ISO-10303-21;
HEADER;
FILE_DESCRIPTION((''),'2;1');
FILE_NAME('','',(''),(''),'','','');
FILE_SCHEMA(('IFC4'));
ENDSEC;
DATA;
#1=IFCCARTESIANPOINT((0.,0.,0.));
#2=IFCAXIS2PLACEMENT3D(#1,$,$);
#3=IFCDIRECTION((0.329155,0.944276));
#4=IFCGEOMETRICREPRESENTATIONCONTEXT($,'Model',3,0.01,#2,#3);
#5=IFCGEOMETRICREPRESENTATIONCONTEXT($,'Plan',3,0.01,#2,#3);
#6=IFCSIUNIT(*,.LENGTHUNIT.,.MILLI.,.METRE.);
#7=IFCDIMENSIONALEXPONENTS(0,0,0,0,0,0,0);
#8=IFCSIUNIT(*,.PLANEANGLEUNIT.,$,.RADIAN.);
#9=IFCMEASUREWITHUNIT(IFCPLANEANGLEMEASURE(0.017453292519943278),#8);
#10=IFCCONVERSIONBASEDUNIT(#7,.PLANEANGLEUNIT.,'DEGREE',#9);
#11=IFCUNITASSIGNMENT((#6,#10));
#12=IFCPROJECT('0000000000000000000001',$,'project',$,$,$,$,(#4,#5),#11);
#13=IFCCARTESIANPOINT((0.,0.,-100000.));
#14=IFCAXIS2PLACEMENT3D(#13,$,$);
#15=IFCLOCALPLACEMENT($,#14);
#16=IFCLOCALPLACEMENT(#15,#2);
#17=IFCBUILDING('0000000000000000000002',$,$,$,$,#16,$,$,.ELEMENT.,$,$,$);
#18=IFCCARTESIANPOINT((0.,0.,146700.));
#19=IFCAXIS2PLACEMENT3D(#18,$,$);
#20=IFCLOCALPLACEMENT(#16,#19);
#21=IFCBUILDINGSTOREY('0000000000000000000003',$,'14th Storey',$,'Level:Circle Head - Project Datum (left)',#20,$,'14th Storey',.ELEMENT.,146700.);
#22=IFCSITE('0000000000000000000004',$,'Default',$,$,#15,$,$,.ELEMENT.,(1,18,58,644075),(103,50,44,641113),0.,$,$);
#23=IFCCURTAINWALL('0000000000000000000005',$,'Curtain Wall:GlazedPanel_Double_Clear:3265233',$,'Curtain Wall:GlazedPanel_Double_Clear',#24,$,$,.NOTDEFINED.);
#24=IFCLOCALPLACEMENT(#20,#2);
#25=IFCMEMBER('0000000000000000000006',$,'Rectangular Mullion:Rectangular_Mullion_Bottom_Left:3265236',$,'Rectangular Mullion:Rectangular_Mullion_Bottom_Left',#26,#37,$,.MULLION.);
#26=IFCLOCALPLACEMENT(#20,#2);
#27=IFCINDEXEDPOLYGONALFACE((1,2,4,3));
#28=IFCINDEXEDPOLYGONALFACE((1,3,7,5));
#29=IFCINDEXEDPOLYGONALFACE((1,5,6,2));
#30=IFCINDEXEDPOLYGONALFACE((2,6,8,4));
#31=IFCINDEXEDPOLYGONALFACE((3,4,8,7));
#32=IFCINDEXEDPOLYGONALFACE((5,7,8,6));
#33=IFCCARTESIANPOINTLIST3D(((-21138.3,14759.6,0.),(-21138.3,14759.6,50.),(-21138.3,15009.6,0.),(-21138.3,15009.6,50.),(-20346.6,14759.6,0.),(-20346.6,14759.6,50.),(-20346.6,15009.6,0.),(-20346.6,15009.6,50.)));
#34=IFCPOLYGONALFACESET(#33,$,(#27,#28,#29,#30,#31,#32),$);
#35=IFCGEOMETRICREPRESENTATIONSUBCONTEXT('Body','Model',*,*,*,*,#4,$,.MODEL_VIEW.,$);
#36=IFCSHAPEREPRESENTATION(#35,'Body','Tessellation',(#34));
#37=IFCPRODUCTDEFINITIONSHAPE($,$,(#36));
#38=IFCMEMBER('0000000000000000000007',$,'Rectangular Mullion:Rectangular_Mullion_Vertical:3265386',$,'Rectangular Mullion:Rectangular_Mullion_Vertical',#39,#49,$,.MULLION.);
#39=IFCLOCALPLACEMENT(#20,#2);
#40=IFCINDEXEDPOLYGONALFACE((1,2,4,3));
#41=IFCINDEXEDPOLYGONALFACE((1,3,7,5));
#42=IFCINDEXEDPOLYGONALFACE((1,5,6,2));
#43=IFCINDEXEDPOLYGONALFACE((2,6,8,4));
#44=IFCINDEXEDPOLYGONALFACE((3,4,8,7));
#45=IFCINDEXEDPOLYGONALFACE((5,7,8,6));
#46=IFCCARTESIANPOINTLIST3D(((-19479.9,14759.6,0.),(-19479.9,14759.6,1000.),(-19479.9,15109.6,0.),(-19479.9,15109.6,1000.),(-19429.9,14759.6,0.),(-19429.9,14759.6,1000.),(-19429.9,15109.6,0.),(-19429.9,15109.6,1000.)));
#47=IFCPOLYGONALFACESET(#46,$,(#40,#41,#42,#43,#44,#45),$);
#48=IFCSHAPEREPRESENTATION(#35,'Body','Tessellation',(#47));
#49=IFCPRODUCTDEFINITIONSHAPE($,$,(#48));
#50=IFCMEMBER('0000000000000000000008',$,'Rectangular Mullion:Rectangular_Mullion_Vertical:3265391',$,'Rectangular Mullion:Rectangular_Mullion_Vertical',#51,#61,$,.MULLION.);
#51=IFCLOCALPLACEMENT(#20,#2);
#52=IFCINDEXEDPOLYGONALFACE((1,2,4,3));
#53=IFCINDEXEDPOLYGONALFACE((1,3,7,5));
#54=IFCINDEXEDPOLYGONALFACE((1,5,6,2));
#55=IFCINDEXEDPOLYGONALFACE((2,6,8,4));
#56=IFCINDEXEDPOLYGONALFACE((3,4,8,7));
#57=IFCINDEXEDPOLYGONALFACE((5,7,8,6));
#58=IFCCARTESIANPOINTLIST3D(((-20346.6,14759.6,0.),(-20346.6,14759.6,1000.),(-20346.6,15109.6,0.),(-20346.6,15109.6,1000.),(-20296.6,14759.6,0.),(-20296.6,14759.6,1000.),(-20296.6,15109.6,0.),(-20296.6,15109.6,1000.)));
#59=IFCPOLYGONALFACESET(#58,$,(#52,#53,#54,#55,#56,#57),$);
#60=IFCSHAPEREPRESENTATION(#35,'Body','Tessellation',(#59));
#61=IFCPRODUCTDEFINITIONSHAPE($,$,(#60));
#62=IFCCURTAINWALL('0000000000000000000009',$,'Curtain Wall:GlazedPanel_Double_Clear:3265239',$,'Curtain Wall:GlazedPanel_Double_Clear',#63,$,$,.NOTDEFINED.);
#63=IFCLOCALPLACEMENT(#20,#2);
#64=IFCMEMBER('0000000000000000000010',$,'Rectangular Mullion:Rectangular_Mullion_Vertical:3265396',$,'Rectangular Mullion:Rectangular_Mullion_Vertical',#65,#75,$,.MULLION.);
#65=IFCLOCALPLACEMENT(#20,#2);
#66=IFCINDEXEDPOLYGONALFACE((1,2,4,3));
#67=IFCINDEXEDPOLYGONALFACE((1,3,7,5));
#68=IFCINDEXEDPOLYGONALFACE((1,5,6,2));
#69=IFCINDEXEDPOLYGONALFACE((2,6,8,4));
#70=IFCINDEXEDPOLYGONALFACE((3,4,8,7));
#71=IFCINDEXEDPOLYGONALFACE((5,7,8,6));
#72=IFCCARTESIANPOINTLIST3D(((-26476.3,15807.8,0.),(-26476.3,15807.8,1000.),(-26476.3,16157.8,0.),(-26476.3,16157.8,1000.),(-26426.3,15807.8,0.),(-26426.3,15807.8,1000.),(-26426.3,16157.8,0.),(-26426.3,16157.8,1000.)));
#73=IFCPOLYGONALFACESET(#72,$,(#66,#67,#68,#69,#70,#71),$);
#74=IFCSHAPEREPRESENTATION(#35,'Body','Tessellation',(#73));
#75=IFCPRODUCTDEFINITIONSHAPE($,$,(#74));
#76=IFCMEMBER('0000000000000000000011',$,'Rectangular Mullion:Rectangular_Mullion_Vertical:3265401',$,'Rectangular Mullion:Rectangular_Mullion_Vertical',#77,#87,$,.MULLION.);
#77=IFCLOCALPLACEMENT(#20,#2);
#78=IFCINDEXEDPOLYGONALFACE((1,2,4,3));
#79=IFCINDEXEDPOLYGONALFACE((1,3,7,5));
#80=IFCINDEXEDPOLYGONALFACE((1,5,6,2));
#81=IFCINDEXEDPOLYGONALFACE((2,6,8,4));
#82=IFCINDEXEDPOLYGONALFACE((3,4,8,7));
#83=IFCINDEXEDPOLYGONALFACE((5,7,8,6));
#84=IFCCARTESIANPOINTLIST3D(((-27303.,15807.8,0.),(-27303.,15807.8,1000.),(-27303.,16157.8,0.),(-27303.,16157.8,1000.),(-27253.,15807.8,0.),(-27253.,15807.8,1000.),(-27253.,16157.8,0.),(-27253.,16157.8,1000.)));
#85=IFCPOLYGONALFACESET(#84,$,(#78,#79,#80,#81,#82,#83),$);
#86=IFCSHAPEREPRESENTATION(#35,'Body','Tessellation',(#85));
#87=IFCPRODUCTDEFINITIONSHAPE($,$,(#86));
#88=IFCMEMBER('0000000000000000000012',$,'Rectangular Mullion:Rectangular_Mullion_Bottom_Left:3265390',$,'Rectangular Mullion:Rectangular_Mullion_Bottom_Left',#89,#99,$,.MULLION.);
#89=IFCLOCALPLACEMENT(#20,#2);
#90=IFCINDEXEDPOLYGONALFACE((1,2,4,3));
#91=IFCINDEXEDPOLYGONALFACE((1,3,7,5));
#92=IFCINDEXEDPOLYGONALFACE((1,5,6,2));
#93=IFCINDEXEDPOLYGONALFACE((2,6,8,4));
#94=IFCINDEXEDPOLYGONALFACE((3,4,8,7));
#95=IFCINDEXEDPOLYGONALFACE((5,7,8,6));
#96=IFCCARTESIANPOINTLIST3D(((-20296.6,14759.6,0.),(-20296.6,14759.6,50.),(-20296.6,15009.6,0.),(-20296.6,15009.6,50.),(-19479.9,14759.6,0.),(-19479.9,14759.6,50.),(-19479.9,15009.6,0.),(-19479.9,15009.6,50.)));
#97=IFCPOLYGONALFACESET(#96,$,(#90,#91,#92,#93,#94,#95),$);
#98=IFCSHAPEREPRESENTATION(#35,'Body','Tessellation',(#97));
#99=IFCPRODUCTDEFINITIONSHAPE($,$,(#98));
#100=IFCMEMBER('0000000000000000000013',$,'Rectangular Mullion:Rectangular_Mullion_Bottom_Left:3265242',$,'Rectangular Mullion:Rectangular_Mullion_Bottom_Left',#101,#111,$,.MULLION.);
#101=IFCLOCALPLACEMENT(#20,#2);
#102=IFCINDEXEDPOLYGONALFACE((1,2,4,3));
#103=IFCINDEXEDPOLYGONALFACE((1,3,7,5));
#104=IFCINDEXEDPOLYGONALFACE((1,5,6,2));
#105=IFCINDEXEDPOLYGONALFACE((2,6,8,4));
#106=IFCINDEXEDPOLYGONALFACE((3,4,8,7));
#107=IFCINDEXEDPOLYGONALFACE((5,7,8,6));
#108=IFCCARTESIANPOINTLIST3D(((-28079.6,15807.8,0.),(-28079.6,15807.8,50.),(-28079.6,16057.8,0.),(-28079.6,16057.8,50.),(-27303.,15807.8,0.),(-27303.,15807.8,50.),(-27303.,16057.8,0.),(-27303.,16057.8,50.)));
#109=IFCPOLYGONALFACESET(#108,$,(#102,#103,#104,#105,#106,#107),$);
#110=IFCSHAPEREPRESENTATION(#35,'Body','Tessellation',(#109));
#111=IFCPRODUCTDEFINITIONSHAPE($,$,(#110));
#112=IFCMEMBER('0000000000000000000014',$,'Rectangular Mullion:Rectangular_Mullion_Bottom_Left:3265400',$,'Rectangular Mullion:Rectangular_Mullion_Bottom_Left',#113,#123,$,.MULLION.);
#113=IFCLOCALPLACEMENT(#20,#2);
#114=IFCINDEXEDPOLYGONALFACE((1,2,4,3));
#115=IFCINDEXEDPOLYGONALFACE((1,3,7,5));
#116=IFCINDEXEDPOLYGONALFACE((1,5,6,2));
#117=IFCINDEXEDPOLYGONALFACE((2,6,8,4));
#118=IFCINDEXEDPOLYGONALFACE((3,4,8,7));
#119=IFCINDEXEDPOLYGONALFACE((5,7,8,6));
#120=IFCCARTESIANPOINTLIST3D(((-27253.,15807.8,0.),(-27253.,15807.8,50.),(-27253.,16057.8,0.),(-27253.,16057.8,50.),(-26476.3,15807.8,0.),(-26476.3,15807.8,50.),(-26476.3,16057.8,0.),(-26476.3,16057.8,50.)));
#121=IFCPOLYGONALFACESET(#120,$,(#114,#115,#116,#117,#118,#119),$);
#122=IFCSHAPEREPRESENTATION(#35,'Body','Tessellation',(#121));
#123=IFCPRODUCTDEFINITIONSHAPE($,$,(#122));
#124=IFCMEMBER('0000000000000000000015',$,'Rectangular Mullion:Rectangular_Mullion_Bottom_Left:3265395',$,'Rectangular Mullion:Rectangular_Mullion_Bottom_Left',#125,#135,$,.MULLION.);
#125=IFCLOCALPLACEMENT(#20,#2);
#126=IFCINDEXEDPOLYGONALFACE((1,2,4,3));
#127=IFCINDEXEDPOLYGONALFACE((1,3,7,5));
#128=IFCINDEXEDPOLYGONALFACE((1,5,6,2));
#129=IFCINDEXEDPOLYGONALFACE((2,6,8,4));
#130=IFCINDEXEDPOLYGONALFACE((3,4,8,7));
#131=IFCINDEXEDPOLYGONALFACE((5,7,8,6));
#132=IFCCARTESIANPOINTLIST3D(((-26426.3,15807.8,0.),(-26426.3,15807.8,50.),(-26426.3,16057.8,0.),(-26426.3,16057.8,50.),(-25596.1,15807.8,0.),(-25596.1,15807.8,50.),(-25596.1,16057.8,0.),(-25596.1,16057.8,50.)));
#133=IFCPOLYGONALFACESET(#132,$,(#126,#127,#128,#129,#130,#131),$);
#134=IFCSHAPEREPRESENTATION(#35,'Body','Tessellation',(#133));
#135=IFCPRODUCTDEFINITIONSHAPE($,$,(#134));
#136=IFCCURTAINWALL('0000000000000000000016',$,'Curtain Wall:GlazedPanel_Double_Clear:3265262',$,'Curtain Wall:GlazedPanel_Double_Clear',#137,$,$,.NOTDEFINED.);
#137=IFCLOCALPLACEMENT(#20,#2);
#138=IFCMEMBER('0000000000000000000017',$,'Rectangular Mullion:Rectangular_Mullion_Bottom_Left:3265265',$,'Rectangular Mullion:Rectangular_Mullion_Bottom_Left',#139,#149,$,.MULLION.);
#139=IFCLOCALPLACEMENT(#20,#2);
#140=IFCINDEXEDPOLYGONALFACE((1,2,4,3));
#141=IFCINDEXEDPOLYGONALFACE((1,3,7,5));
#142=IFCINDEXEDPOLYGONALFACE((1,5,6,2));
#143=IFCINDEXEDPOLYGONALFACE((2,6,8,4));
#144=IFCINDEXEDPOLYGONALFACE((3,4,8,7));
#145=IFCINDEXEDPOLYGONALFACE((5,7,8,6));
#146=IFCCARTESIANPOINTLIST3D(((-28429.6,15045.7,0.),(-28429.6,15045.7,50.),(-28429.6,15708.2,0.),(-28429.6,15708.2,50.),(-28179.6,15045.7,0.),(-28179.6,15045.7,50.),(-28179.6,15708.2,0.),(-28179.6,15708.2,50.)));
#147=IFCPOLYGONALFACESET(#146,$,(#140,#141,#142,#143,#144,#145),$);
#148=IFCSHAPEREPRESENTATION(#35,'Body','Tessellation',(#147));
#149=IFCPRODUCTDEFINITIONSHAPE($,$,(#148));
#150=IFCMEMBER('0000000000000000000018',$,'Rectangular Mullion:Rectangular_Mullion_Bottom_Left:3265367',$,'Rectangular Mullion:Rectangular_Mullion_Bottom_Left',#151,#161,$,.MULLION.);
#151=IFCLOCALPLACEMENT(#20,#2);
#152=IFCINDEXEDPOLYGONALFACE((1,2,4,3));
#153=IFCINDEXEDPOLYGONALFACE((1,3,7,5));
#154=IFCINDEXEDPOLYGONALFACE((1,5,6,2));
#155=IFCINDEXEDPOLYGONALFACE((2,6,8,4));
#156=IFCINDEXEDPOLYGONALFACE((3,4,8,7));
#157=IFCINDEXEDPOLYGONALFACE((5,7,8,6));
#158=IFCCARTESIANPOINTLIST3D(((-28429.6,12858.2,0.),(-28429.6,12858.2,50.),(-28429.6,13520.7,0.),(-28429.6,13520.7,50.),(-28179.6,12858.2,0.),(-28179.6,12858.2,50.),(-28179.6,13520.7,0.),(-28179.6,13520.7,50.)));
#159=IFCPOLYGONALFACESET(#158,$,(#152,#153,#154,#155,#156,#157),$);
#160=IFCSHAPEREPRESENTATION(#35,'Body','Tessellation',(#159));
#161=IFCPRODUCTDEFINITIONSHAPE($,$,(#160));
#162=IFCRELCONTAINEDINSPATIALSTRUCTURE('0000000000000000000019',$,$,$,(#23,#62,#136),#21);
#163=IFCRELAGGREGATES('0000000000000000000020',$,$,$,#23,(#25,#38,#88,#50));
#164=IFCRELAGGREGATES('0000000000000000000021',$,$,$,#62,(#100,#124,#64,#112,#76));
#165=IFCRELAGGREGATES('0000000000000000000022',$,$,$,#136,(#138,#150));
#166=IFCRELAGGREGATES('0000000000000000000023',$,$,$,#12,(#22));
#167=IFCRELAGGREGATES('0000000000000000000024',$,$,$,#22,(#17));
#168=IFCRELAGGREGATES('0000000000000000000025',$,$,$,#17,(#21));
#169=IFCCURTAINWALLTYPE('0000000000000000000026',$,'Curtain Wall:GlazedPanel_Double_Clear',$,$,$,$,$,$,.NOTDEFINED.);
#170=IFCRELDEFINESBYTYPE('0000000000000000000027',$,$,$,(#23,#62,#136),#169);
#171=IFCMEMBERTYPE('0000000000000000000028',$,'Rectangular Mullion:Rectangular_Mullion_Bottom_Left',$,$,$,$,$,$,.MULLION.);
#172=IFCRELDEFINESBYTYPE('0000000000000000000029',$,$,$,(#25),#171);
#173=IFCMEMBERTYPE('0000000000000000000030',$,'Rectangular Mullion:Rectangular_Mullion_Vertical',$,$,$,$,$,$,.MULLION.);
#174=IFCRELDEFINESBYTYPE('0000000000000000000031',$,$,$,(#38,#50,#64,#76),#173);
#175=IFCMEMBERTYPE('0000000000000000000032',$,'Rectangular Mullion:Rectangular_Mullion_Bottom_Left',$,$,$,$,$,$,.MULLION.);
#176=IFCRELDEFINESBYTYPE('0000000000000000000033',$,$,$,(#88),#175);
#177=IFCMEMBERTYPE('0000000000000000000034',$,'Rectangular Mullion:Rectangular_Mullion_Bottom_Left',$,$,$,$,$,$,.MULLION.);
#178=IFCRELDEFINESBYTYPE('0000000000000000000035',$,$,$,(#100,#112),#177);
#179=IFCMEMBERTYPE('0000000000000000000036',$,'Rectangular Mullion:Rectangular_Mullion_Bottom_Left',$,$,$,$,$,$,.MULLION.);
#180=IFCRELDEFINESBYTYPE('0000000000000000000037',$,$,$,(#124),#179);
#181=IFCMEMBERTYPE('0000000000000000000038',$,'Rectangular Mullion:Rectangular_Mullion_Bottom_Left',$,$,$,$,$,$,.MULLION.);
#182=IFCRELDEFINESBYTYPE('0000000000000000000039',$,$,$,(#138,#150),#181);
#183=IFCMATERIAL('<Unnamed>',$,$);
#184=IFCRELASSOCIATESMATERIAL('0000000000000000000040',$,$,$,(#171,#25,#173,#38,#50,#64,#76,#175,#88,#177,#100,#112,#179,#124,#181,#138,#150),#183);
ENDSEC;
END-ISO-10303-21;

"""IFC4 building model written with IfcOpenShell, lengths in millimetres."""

from ifc_helpers import new_model, entity, si_unit, converted_unit, direction, frame, origin, place, context, subcontext, project, spatial, indexed_curve, outline, extrude, source, transform, mapped, material, type_object, type_shapes, element, aggregate, save


model = new_model("IFC4")

# Units and contexts
model_context = context("Model", 3, precision=0.01, world=origin(), true_north=direction((0.329155, 0.944276)))
plan_context = context("Plan", 3, precision=0.01, world=origin(), true_north=direction((0.329155, 0.944276)))
body_context = subcontext(model_context, "Body", "Model", "MODEL_VIEW")
ifc_project = project(units=[si_unit("LENGTHUNIT", "METRE", prefix="MILLI"), converted_unit("PLANEANGLEUNIT", "DEGREE", entity("IfcPlaneAngleMeasure", 0.017453292519943278), si_unit("PLANEANGLEUNIT", "RADIAN"), dimensions=[0, 0, 0, 0, 0, 0, 0])], contexts=[model_context, plan_context])

# Site, building, storey
site_placement = place(None, frame((0.0, 0.0, -100000.0)))
site = spatial("IfcSite", under=ifc_project, at=site_placement, Name="Default", CompositionType="ELEMENT", RefLatitude=(1, 18, 58, 644075), RefLongitude=(103, 50, 44, 641113), RefElevation=0.0)
building_placement = place(site_placement, origin())
building = spatial("IfcBuilding", under=site, at=building_placement, CompositionType="ELEMENT")
storey_placement = place(building_placement, frame((0.0, 0.0, 146700.0)))
storey = spatial("IfcBuildingStorey", under=building, at=storey_placement, Name="14th Storey", ObjectType="Level:Circle Head - Project Datum (left)", LongName="14th Storey", CompositionType="ELEMENT", Elevation=146700.0)

# Curtain walls, members
curtain_wall_type = type_object("IfcCurtainWallType", Name="Curtain Wall:GlazedPanel_Double_Clear", PredefinedType="NOTDEFINED")
curtain_wall_1_placement = place(storey_placement, frame((0.0, 0.0, -146700.0)))
curtain_wall_1 = element("IfcCurtainWall", 1, at=curtain_wall_1_placement, inside=storey, type_object=curtain_wall_type, Name="Curtain Wall:GlazedPanel_Double_Clear:3265233", ObjectType="Curtain Wall:GlazedPanel_Double_Clear", PredefinedType="NOTDEFINED")
ifc_material_1 = material(Name="<Unnamed>")
member_type_1 = type_object("IfcMemberType", Name="Rectangular Mullion:Rectangular_Mullion_Bottom_Left", PredefinedType="MULLION", material=ifc_material_1)
shared_shape_1 = source(origin(), body_context, "Body", "SweptSolid", [
    extrude(outline(indexed_curve([(-25.0, -125.0), (25.0, -125.0), (25.0, 125.0), (-25.0, 125.0), (-25.0, -125.0)], self_intersect=False)), frame((-25.0, 0.0, -791.7), z_axis=(0.0, 0.0, 1.0), x_axis=(-1.0, 0.0, 0.0)), (0.0, 0.0, 1.0), 791.7),
])
type_shapes(member_type_1, [shared_shape_1])
member_1_placement = place(curtain_wall_1_placement, frame((-21138.3, 14884.6, 146700.0), z_axis=(-1.0, 0.0, 0.0), x_axis=(0.0, 0.0, -1.0)))
member_1 = element("IfcMember", 2, at=member_1_placement, type_object=member_type_1, material=ifc_material_1, Name="Rectangular Mullion:Rectangular_Mullion_Bottom_Left:3265236", ObjectType="Rectangular Mullion:Rectangular_Mullion_Bottom_Left", PredefinedType="MULLION", context=body_context, shape_type="MappedRepresentation", body=[
    mapped(shared_shape_1, transform((0.0, 0.0, 0.0), scale=1.0)),
])
member_type_2 = type_object("IfcMemberType", Name="Rectangular Mullion:Rectangular_Mullion_Vertical", PredefinedType="MULLION", material=ifc_material_1)
shared_shape_2 = source(origin(), body_context, "Body", "SweptSolid", [
    extrude(outline(indexed_curve([(-25.0, -175.0), (25.0, -175.0), (25.0, 175.0), (-25.0, 175.0), (-25.0, -175.0)], self_intersect=False)), frame((0.0, -50.0, -1000.0), z_axis=(0.0, 0.0, 1.0), x_axis=(-1.0, 0.0, 0.0)), (0.0, 0.0, 1.0), 1000.0),
])
type_shapes(member_type_2, [shared_shape_2])
member_2_placement = place(curtain_wall_1_placement, frame((-19454.9, 14884.6, 146700.0), z_axis=(0.0, 0.0, -1.0), x_axis=(1.0, 0.0, 0.0)))
member_2 = element("IfcMember", 3, at=member_2_placement, type_object=member_type_2, material=ifc_material_1, Name="Rectangular Mullion:Rectangular_Mullion_Vertical:3265386", ObjectType="Rectangular Mullion:Rectangular_Mullion_Vertical", PredefinedType="MULLION", context=body_context, shape_type="MappedRepresentation", body=[
    mapped(shared_shape_2, transform((0.0, 0.0, 0.0), scale=1.0)),
])
member_3_placement = place(curtain_wall_1_placement, frame((-20321.6, 14884.6, 146700.0), z_axis=(0.0, 0.0, -1.0), x_axis=(1.0, 0.0, 0.0)))
member_3 = element("IfcMember", 4, at=member_3_placement, type_object=member_type_2, material=ifc_material_1, Name="Rectangular Mullion:Rectangular_Mullion_Vertical:3265391", ObjectType="Rectangular Mullion:Rectangular_Mullion_Vertical", PredefinedType="MULLION", context=body_context, shape_type="MappedRepresentation", body=[
    mapped(shared_shape_2, transform((0.0, 0.0, 0.0), scale=1.0)),
])
curtain_wall_2_placement = place(storey_placement, frame((0.0, 0.0, -146700.0)))
curtain_wall_2 = element("IfcCurtainWall", 5, at=curtain_wall_2_placement, inside=storey, type_object=curtain_wall_type, Name="Curtain Wall:GlazedPanel_Double_Clear:3265239", ObjectType="Curtain Wall:GlazedPanel_Double_Clear", PredefinedType="NOTDEFINED")
member_4_placement = place(curtain_wall_2_placement, frame((-26451.3, 15932.8, 146700.0), z_axis=(0.0, 0.0, -1.0), x_axis=(1.0, 0.0, 0.0)))
member_4 = element("IfcMember", 6, at=member_4_placement, type_object=member_type_2, material=ifc_material_1, Name="Rectangular Mullion:Rectangular_Mullion_Vertical:3265396", ObjectType="Rectangular Mullion:Rectangular_Mullion_Vertical", PredefinedType="MULLION", context=body_context, shape_type="MappedRepresentation", body=[
    mapped(shared_shape_2, transform((0.0, 0.0, 0.0), scale=1.0)),
])
member_5_placement = place(curtain_wall_2_placement, frame((-27278.0, 15932.8, 146700.0), z_axis=(0.0, 0.0, -1.0), x_axis=(1.0, 0.0, 0.0)))
member_5 = element("IfcMember", 7, at=member_5_placement, type_object=member_type_2, material=ifc_material_1, Name="Rectangular Mullion:Rectangular_Mullion_Vertical:3265401", ObjectType="Rectangular Mullion:Rectangular_Mullion_Vertical", PredefinedType="MULLION", context=body_context, shape_type="MappedRepresentation", body=[
    mapped(shared_shape_2, transform((0.0, 0.0, 0.0), scale=1.0)),
])

# Members
member_type_3 = type_object("IfcMemberType", Name="Rectangular Mullion:Rectangular_Mullion_Bottom_Left", PredefinedType="MULLION", material=ifc_material_1)
shared_shape_3 = source(origin(), body_context, "Body", "SweptSolid", [
    extrude(outline(indexed_curve([(-25.0, -125.0), (25.0, -125.0), (25.0, 125.0), (-25.0, 125.0), (-25.0, -125.0)], self_intersect=False)), frame((-25.0, 0.0, -816.7), z_axis=(0.0, 0.0, 1.0), x_axis=(-1.0, 0.0, 0.0)), (0.0, 0.0, 1.0), 816.7),
])
type_shapes(member_type_3, [shared_shape_3])
member_6_placement = place(curtain_wall_1_placement, frame((-20296.6, 14884.6, 146700.0), z_axis=(-1.0, 0.0, 0.0), x_axis=(0.0, 0.0, -1.0)))
member_6 = element("IfcMember", 8, at=member_6_placement, type_object=member_type_3, material=ifc_material_1, Name="Rectangular Mullion:Rectangular_Mullion_Bottom_Left:3265390", ObjectType="Rectangular Mullion:Rectangular_Mullion_Bottom_Left", PredefinedType="MULLION", context=body_context, shape_type="MappedRepresentation", body=[
    mapped(shared_shape_3, transform((0.0, 0.0, 0.0), scale=1.0)),
])
aggregate(curtain_wall_1, [member_1, member_2, member_6, member_3])
member_type_4 = type_object("IfcMemberType", Name="Rectangular Mullion:Rectangular_Mullion_Bottom_Left", PredefinedType="MULLION", material=ifc_material_1)
shared_shape_4 = source(origin(), body_context, "Body", "SweptSolid", [
    extrude(outline(indexed_curve([(-25.0, -125.0), (25.0, -125.0), (25.0, 125.0), (-25.0, 125.0), (-25.0, -125.0)], self_intersect=False)), frame((-25.0, 0.0, -776.7), z_axis=(0.0, 0.0, 1.0), x_axis=(-1.0, 0.0, 0.0)), (0.0, 0.0, 1.0), 776.7),
])
type_shapes(member_type_4, [shared_shape_4])
member_7_placement = place(curtain_wall_2_placement, frame((-28079.6, 15932.8, 146700.0), z_axis=(-1.0, 0.0, 0.0), x_axis=(0.0, 0.0, -1.0)))
member_7 = element("IfcMember", 9, at=member_7_placement, type_object=member_type_4, material=ifc_material_1, Name="Rectangular Mullion:Rectangular_Mullion_Bottom_Left:3265242", ObjectType="Rectangular Mullion:Rectangular_Mullion_Bottom_Left", PredefinedType="MULLION", context=body_context, shape_type="MappedRepresentation", body=[
    mapped(shared_shape_4, transform((0.0, 0.0, 0.0), scale=1.0)),
])
member_8_placement = place(curtain_wall_2_placement, frame((-27253.0, 15932.8, 146700.0), z_axis=(-1.0, 0.0, 0.0), x_axis=(0.0, 0.0, -1.0)))
member_8 = element("IfcMember", 10, at=member_8_placement, type_object=member_type_4, material=ifc_material_1, Name="Rectangular Mullion:Rectangular_Mullion_Bottom_Left:3265400", ObjectType="Rectangular Mullion:Rectangular_Mullion_Bottom_Left", PredefinedType="MULLION", context=body_context, shape_type="MappedRepresentation", body=[
    mapped(shared_shape_4, transform((0.0, 0.0, 0.0), scale=1.0)),
])
member_type_5 = type_object("IfcMemberType", Name="Rectangular Mullion:Rectangular_Mullion_Bottom_Left", PredefinedType="MULLION", material=ifc_material_1)
shared_shape_5 = source(origin(), body_context, "Body", "SweptSolid", [
    extrude(outline(indexed_curve([(-25.0, -125.0), (25.0, -125.0), (25.0, 125.0), (-25.0, 125.0), (-25.0, -125.0)], self_intersect=False)), frame((-25.0, 0.0, -830.2), z_axis=(0.0, 0.0, 1.0), x_axis=(-1.0, 0.0, 0.0)), (0.0, 0.0, 1.0), 830.2),
])
type_shapes(member_type_5, [shared_shape_5])
member_9_placement = place(curtain_wall_2_placement, frame((-26426.3, 15932.8, 146700.0), z_axis=(-1.0, 0.0, 0.0), x_axis=(0.0, 0.0, -1.0)))
member_9 = element("IfcMember", 11, at=member_9_placement, type_object=member_type_5, material=ifc_material_1, Name="Rectangular Mullion:Rectangular_Mullion_Bottom_Left:3265395", ObjectType="Rectangular Mullion:Rectangular_Mullion_Bottom_Left", PredefinedType="MULLION", context=body_context, shape_type="MappedRepresentation", body=[
    mapped(shared_shape_5, transform((0.0, 0.0, 0.0), scale=1.0)),
])
aggregate(curtain_wall_2, [member_7, member_9, member_4, member_8, member_5])

# Curtain wall, members
curtain_wall_3_placement = place(storey_placement, frame((0.0, 0.0, -146700.0)))
curtain_wall_3 = element("IfcCurtainWall", 12, at=curtain_wall_3_placement, inside=storey, type_object=curtain_wall_type, Name="Curtain Wall:GlazedPanel_Double_Clear:3265262", ObjectType="Curtain Wall:GlazedPanel_Double_Clear", PredefinedType="NOTDEFINED")
member_type_6 = type_object("IfcMemberType", Name="Rectangular Mullion:Rectangular_Mullion_Bottom_Left", PredefinedType="MULLION", material=ifc_material_1)
shared_shape_6 = source(origin(), body_context, "Body", "SweptSolid", [
    extrude(outline(indexed_curve([(-25.0, -125.0), (25.0, -125.0), (25.0, 125.0), (-25.0, 125.0), (-25.0, -125.0)], self_intersect=False)), frame((-25.0, 0.0, -662.5), z_axis=(0.0, 0.0, 1.0), x_axis=(-1.0, 0.0, 0.0)), (0.0, 0.0, 1.0), 662.5),
])
type_shapes(member_type_6, [shared_shape_6])
member_10_placement = place(curtain_wall_3_placement, frame((-28304.6, 15708.2, 146700.0), z_axis=(0.0, 1.0, 0.0), x_axis=(0.0, 0.0, -1.0)))
member_10 = element("IfcMember", 13, at=member_10_placement, type_object=member_type_6, material=ifc_material_1, Name="Rectangular Mullion:Rectangular_Mullion_Bottom_Left:3265265", ObjectType="Rectangular Mullion:Rectangular_Mullion_Bottom_Left", PredefinedType="MULLION", context=body_context, shape_type="MappedRepresentation", body=[
    mapped(shared_shape_6, transform((0.0, 0.0, 0.0), scale=1.0)),
])
member_11_placement = place(curtain_wall_3_placement, frame((-28304.6, 13520.7, 146700.0), z_axis=(0.0, 1.0, 0.0), x_axis=(0.0, 0.0, -1.0)))
member_11 = element("IfcMember", 14, at=member_11_placement, type_object=member_type_6, material=ifc_material_1, Name="Rectangular Mullion:Rectangular_Mullion_Bottom_Left:3265367", ObjectType="Rectangular Mullion:Rectangular_Mullion_Bottom_Left", PredefinedType="MULLION", context=body_context, shape_type="MappedRepresentation", body=[
    mapped(shared_shape_6, transform((0.0, 0.0, 0.0), scale=1.0)),
])
aggregate(curtain_wall_3, [member_10, member_11])

save(model, "model.ifc")
